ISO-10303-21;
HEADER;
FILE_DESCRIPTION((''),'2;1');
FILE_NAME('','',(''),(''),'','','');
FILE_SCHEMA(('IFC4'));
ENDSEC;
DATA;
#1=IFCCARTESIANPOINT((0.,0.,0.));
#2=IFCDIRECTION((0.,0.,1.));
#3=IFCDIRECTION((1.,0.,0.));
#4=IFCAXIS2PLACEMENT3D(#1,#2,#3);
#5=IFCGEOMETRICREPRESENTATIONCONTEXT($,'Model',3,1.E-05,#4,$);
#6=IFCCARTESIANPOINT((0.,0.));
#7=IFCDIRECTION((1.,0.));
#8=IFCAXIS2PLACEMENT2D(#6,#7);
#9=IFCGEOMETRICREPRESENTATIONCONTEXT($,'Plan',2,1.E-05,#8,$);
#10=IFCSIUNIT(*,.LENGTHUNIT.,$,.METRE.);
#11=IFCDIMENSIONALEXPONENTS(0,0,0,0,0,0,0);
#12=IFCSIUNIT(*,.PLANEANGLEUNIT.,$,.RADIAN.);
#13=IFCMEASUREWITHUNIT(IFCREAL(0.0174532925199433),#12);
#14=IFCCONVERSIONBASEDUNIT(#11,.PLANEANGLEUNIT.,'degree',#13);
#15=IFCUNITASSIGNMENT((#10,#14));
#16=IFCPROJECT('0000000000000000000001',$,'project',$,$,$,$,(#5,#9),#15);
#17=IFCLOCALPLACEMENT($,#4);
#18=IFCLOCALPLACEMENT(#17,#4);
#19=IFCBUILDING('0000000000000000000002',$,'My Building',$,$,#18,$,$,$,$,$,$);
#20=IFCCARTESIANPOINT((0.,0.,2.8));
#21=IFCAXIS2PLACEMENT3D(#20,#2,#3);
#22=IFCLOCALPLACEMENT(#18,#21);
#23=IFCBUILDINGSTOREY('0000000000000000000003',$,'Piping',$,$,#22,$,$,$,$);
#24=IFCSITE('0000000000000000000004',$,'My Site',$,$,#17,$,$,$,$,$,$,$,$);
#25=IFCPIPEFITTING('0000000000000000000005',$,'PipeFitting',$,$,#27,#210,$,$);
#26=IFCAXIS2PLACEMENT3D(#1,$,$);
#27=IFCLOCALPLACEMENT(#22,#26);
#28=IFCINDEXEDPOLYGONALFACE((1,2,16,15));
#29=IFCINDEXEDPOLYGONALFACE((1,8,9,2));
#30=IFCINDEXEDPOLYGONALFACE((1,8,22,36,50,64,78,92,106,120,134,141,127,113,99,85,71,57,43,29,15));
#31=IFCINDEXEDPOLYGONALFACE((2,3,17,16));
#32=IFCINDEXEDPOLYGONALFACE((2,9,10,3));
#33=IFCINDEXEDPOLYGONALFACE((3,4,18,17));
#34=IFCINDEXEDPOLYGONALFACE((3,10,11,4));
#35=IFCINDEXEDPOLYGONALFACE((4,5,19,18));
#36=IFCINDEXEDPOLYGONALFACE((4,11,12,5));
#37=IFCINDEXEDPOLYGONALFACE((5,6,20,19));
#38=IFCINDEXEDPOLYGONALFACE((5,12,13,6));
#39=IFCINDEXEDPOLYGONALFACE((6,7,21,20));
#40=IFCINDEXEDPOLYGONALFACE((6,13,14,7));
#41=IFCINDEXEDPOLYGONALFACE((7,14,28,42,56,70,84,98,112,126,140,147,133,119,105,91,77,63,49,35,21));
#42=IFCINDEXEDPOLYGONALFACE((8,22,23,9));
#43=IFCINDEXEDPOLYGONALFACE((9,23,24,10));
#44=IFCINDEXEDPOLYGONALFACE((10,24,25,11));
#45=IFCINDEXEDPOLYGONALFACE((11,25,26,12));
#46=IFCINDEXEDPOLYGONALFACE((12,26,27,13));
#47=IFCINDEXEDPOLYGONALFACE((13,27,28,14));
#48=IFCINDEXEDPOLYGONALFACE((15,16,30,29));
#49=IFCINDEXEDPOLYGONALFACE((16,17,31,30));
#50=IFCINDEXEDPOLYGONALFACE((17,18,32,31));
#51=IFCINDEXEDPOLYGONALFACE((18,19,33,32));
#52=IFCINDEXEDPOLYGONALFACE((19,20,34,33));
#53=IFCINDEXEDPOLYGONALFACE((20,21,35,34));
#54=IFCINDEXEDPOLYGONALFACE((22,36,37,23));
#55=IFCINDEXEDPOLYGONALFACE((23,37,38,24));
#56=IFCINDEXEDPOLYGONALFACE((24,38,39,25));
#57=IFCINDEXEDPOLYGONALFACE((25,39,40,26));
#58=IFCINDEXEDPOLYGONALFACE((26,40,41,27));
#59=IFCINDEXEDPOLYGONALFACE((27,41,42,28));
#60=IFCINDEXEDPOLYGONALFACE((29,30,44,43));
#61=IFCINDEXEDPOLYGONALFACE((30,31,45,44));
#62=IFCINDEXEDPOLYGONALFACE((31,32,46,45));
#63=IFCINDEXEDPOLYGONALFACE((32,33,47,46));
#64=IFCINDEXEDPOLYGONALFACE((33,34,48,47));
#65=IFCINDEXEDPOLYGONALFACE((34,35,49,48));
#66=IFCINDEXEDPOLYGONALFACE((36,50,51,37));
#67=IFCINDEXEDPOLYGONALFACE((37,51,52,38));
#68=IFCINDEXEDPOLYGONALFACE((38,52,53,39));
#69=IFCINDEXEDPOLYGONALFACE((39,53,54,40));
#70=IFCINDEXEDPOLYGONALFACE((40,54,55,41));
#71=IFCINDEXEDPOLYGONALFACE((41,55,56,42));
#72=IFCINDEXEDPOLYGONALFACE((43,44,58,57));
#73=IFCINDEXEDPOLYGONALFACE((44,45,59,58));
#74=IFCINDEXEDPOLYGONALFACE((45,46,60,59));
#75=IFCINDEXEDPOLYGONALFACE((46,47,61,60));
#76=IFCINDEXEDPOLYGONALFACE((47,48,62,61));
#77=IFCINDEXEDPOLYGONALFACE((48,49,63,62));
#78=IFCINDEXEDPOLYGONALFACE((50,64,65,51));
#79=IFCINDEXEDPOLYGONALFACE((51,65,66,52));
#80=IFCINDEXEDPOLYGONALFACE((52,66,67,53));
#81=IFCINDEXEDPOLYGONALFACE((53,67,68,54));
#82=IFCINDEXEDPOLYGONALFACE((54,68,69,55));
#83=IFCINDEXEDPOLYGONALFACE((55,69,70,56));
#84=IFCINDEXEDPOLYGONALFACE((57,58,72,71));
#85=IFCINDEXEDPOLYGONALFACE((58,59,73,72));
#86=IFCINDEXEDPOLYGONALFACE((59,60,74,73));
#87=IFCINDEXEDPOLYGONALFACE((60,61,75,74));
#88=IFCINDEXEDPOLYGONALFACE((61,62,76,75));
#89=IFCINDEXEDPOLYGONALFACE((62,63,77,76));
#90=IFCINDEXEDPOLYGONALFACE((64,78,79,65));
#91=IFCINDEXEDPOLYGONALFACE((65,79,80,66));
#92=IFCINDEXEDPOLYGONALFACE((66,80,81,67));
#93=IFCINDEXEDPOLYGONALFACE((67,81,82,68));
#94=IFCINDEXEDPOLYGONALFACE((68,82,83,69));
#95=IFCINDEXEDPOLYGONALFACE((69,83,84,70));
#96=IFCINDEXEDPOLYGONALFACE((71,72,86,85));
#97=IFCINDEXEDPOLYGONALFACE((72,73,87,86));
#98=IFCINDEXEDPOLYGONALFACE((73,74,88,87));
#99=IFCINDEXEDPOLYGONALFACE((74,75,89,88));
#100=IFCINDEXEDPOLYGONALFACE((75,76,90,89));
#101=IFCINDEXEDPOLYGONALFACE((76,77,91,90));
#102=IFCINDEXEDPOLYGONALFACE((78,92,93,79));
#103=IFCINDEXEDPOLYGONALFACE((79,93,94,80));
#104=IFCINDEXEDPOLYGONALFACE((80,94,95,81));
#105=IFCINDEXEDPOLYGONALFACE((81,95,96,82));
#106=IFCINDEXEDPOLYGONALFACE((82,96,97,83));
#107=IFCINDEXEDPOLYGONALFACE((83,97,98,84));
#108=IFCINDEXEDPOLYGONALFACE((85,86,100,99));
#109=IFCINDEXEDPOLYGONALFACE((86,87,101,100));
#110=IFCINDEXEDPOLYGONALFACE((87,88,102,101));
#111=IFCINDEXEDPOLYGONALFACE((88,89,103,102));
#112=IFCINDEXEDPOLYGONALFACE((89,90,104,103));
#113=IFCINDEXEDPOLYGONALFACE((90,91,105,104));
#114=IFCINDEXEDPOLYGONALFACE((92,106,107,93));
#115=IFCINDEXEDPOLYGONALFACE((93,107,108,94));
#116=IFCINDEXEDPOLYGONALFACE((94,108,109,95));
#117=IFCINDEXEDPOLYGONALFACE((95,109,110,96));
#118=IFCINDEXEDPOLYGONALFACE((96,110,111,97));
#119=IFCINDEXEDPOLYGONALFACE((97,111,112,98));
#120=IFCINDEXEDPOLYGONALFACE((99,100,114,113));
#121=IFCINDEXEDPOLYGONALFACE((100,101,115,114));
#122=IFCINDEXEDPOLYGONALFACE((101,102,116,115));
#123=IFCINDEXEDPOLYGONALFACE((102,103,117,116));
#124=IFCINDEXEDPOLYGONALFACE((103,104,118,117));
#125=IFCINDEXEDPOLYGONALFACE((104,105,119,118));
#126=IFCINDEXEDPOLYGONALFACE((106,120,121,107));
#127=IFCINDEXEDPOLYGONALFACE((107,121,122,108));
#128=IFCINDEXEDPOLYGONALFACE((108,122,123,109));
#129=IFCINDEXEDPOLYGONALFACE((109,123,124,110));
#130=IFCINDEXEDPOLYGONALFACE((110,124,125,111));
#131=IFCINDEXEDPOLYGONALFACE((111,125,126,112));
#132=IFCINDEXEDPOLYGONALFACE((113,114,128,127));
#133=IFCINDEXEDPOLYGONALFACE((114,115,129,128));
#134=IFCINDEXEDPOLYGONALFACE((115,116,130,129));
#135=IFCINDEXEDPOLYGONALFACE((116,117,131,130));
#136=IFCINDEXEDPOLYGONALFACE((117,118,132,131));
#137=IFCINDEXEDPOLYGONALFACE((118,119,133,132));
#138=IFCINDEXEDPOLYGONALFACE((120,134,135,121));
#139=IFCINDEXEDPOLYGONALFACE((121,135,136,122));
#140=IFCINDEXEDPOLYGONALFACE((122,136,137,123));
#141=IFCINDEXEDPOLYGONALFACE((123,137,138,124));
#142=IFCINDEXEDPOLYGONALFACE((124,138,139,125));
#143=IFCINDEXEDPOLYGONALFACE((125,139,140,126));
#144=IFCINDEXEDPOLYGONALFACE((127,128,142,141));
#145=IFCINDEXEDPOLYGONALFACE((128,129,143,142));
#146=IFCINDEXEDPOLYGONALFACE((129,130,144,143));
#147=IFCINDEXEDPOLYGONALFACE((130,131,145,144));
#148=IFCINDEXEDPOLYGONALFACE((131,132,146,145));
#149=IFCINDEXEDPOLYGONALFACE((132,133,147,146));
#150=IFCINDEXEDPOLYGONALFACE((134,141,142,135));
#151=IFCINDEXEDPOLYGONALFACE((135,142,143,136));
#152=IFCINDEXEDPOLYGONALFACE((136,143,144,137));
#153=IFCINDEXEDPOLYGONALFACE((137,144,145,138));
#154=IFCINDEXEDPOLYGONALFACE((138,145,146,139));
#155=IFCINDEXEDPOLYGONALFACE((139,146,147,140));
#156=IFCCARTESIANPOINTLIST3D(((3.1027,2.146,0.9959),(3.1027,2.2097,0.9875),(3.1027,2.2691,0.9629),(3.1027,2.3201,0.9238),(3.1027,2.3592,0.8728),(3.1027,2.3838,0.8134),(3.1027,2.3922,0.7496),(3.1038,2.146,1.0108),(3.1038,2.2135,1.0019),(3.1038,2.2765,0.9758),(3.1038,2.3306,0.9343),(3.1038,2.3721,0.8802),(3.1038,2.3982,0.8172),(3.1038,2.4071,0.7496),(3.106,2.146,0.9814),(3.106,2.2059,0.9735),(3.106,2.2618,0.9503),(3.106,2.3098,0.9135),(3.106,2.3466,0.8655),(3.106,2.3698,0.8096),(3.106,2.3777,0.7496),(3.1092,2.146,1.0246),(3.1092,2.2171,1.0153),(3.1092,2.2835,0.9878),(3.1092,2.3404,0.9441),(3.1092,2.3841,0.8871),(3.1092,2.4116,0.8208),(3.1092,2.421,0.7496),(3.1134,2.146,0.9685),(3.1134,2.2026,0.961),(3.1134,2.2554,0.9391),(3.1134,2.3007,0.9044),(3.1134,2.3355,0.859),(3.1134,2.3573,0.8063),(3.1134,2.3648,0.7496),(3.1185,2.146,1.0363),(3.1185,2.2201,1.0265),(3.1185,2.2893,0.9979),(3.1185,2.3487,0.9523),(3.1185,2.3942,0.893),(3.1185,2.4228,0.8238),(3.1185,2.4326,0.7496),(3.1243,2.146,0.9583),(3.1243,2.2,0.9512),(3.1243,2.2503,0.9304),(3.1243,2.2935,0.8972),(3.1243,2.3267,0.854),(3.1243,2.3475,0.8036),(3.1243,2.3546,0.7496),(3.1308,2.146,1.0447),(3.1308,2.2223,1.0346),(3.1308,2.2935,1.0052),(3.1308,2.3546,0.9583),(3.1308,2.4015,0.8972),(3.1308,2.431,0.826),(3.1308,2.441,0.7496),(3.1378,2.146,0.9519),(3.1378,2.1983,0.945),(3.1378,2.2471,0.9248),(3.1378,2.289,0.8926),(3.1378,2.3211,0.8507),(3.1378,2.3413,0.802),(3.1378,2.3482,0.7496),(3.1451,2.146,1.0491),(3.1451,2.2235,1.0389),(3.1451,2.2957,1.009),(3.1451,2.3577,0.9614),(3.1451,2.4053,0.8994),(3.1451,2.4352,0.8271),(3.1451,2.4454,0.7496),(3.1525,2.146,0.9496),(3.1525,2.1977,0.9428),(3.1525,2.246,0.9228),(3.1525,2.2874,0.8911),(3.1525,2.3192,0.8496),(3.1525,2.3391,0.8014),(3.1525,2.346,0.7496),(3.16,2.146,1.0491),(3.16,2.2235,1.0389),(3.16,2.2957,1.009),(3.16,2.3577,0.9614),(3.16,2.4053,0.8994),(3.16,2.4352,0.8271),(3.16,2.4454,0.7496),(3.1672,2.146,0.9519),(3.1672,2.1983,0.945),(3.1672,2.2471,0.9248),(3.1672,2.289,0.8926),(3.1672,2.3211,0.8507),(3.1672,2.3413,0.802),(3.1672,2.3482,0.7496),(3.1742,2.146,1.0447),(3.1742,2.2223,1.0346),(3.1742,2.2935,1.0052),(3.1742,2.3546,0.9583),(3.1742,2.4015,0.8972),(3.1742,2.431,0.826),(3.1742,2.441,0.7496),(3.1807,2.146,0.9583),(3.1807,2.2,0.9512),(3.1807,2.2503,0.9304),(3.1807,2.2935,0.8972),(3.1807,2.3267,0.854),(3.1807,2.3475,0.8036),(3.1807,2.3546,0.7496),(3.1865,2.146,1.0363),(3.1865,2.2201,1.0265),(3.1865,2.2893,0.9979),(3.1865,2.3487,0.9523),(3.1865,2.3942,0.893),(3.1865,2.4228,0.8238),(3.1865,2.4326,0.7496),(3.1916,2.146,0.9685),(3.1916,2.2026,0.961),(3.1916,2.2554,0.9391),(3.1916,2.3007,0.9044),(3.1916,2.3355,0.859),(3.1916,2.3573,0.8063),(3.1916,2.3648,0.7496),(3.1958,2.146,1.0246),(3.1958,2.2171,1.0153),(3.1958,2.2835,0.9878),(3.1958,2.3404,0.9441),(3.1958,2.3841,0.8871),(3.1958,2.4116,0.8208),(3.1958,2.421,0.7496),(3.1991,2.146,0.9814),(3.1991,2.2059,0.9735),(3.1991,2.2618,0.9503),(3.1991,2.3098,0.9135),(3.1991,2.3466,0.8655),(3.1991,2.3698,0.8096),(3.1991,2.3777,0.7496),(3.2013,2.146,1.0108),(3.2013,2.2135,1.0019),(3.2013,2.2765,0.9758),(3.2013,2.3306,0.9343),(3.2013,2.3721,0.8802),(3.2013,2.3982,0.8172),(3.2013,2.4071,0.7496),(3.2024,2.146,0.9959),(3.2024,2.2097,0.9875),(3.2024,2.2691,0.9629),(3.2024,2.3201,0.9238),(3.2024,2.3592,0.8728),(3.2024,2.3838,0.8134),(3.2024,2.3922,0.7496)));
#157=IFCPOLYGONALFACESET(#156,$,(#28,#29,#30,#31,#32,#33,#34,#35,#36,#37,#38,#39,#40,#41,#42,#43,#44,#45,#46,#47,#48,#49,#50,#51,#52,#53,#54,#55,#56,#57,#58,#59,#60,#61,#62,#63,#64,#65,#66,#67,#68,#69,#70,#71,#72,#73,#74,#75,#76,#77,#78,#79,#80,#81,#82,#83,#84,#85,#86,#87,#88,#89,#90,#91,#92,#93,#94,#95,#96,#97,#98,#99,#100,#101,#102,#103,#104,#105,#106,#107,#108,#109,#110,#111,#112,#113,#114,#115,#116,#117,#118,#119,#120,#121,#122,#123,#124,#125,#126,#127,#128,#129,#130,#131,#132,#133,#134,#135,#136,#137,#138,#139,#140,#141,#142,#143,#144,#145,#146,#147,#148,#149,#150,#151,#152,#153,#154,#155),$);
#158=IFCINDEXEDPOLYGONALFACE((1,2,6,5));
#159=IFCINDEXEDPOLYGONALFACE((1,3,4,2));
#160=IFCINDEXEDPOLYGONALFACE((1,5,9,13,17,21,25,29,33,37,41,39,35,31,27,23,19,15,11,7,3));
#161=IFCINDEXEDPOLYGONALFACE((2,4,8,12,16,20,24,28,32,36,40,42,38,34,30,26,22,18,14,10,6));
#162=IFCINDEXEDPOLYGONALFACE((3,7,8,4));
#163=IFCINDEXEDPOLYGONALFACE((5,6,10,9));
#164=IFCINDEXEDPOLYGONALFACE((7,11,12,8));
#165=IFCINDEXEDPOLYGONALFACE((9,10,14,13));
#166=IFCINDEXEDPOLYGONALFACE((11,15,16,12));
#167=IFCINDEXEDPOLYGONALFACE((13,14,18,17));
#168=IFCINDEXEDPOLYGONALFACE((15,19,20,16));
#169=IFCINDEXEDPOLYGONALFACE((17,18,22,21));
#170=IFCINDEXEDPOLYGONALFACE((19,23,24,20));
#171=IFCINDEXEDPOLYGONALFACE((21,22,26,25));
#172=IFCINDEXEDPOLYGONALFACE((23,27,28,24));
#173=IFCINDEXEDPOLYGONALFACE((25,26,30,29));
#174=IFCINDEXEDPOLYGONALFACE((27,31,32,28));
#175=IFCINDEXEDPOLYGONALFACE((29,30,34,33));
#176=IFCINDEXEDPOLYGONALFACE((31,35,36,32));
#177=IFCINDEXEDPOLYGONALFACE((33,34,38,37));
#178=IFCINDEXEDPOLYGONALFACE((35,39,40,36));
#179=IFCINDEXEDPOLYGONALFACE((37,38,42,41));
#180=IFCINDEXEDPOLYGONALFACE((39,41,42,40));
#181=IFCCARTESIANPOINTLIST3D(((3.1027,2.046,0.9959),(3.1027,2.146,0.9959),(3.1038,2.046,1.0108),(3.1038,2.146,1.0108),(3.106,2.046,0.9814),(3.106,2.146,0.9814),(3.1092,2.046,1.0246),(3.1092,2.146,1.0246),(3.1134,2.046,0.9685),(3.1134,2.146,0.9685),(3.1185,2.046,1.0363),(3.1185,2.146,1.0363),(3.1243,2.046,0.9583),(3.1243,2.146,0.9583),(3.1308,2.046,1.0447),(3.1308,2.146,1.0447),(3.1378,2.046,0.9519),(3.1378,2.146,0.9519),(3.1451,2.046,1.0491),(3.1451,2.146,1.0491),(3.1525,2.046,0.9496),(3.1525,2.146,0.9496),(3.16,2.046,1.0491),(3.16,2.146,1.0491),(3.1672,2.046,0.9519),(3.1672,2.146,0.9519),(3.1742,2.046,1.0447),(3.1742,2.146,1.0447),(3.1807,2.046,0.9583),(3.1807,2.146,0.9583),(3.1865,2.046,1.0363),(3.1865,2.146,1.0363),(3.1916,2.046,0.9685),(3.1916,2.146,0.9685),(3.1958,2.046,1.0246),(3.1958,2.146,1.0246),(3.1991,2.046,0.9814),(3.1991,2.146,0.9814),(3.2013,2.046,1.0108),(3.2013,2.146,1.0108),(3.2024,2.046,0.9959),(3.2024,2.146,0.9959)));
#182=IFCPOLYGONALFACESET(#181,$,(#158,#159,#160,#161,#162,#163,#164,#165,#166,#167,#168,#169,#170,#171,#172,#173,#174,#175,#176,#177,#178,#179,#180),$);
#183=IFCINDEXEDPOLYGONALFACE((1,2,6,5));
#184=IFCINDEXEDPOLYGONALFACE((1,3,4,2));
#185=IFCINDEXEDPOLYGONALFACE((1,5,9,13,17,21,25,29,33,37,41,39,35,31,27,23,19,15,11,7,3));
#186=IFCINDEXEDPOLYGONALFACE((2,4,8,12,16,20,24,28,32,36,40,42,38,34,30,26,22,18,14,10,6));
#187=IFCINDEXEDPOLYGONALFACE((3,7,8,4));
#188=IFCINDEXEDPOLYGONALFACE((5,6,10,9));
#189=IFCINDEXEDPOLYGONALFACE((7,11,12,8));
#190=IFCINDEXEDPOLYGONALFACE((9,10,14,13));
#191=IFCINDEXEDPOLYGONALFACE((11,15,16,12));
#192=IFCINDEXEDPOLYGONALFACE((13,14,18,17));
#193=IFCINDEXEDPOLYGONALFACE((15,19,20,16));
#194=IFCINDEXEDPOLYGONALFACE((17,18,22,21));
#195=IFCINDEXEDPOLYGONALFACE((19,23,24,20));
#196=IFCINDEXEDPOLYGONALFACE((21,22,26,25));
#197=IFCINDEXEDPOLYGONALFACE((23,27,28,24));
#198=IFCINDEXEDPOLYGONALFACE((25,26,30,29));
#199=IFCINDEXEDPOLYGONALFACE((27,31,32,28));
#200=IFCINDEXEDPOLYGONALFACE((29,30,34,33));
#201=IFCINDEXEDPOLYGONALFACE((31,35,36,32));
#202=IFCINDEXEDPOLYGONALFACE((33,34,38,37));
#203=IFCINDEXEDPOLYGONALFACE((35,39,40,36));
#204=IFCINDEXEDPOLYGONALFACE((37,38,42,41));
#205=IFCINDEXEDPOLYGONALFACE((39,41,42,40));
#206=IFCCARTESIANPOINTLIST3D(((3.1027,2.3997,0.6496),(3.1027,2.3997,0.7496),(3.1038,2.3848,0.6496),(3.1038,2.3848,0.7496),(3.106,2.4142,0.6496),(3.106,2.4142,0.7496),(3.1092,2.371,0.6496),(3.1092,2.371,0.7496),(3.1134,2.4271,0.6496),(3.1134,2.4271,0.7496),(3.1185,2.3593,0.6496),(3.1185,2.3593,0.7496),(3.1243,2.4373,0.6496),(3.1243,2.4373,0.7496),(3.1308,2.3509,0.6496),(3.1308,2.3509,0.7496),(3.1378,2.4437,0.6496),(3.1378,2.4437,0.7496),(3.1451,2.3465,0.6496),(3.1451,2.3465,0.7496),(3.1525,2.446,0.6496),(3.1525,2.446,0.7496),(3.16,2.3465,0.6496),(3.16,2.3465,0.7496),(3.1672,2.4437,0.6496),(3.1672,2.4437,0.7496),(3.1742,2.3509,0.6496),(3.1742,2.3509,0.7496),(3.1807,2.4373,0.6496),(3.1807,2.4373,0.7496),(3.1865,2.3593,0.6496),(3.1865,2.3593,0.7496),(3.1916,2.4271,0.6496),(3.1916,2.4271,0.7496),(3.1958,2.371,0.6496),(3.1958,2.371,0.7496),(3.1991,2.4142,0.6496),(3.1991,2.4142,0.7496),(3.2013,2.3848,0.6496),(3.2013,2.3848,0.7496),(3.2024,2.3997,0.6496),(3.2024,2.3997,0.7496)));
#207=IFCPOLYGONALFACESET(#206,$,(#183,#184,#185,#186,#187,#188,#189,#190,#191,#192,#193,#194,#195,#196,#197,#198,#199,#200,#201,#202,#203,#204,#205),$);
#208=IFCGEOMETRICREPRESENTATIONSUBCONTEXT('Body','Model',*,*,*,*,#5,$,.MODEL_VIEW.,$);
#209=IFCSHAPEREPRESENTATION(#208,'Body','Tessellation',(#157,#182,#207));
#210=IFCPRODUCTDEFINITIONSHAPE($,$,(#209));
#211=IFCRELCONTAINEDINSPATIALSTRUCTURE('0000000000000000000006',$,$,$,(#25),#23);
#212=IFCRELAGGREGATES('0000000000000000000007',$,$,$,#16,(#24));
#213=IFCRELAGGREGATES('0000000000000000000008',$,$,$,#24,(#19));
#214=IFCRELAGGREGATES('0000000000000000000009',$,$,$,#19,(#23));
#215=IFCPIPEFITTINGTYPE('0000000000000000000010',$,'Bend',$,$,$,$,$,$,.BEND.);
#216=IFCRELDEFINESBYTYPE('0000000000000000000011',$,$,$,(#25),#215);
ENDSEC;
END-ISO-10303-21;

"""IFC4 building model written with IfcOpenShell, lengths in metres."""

from ifc_helpers import new_model, entity, si_unit, converted_unit, frame, origin_with_axes, origin_2d_with_axis, place, context, subcontext, project, spatial, circle, extrude, source, transform, mapped, type_object, type_shapes, element, save


model = new_model("IFC4")

# Units and contexts
model_context = context("Model", 3, precision=1e-05, world=origin_with_axes())
plan_context = context("Plan", 2, precision=1e-05, world=origin_2d_with_axis())
body_context = subcontext(model_context, "Body", "Model", "MODEL_VIEW")
ifc_project = project(units=[si_unit("LENGTHUNIT", "METRE"), converted_unit("PLANEANGLEUNIT", "degree", entity("IfcReal", 0.0174532925199433), si_unit("PLANEANGLEUNIT", "RADIAN"), dimensions=[0, 0, 0, 0, 0, 0, 0])], contexts=[model_context, plan_context])

# Site, building, storey
site_placement = place(None, origin_with_axes())
site = spatial("IfcSite", under=ifc_project, at=site_placement, Name="My Site")
building_placement = place(site_placement, origin_with_axes())
building = spatial("IfcBuilding", under=site, at=building_placement, Name="My Building")
storey_placement = place(building_placement, frame((0.0, 0.0, 2.8), z_axis=(0.0, 0.0, 1.0), x_axis=(1.0, 0.0, 0.0)))
storey = spatial("IfcBuildingStorey", under=building, at=storey_placement, Name="Piping")

# Pipe fitting
pipe_fitting_type_1 = type_object("IfcPipeFittingType", Name="Bend", PredefinedType="BEND")
shared_shape = source(origin_with_axes(), body_context, "Body", "SolidModel", [
    entity("IfcSweptDiskSolid", entity("IfcIndexedPolyCurve", entity("IfcCartesianPointList3D", [[0.0, 0.0, 0.1], [0.0732, 0.0, 0.2768], [0.25, 0.0, 0.35]]), [entity("IfcArcIndex", [1, 2, 3])]), 0.05),
    extrude(circle(Radius=0.05), origin_with_axes(), (0.0, 0.0, 1.0), 0.1),
    extrude(circle(Radius=0.05), frame((0.25, 0.0, 0.35), z_axis=(1.0, 0.0, 0.0), x_axis=(0.0, 0.0, 1.0)), (0.0, 0.0, 1.0), 0.1),
])
type_shapes(pipe_fitting_type_1, [shared_shape])
for number, where, z_axis, x_axis, name in (
    (1, (3.1525, 2.046, 0.9996), (0.0, 1.0, 0.0), (0.0, 0.0, -1.0), "PipeFitting"),
):
    element("IfcPipeFitting", number, at=place(storey_placement, frame(where, z_axis=z_axis, x_axis=x_axis)), inside=storey, type_object=pipe_fitting_type_1, Name=name, context=body_context, shape_type="MappedRepresentation", body=[
        mapped(shared_shape, transform((0.0, 0.0, 0.0), x_axis=(1.0, 0.0, 0.0), y_axis=(0.0, 1.0, 0.0), z_axis=(0.0, 0.0, 1.0), scale=1.0)),
    ])

save(model, "model.ifc")
